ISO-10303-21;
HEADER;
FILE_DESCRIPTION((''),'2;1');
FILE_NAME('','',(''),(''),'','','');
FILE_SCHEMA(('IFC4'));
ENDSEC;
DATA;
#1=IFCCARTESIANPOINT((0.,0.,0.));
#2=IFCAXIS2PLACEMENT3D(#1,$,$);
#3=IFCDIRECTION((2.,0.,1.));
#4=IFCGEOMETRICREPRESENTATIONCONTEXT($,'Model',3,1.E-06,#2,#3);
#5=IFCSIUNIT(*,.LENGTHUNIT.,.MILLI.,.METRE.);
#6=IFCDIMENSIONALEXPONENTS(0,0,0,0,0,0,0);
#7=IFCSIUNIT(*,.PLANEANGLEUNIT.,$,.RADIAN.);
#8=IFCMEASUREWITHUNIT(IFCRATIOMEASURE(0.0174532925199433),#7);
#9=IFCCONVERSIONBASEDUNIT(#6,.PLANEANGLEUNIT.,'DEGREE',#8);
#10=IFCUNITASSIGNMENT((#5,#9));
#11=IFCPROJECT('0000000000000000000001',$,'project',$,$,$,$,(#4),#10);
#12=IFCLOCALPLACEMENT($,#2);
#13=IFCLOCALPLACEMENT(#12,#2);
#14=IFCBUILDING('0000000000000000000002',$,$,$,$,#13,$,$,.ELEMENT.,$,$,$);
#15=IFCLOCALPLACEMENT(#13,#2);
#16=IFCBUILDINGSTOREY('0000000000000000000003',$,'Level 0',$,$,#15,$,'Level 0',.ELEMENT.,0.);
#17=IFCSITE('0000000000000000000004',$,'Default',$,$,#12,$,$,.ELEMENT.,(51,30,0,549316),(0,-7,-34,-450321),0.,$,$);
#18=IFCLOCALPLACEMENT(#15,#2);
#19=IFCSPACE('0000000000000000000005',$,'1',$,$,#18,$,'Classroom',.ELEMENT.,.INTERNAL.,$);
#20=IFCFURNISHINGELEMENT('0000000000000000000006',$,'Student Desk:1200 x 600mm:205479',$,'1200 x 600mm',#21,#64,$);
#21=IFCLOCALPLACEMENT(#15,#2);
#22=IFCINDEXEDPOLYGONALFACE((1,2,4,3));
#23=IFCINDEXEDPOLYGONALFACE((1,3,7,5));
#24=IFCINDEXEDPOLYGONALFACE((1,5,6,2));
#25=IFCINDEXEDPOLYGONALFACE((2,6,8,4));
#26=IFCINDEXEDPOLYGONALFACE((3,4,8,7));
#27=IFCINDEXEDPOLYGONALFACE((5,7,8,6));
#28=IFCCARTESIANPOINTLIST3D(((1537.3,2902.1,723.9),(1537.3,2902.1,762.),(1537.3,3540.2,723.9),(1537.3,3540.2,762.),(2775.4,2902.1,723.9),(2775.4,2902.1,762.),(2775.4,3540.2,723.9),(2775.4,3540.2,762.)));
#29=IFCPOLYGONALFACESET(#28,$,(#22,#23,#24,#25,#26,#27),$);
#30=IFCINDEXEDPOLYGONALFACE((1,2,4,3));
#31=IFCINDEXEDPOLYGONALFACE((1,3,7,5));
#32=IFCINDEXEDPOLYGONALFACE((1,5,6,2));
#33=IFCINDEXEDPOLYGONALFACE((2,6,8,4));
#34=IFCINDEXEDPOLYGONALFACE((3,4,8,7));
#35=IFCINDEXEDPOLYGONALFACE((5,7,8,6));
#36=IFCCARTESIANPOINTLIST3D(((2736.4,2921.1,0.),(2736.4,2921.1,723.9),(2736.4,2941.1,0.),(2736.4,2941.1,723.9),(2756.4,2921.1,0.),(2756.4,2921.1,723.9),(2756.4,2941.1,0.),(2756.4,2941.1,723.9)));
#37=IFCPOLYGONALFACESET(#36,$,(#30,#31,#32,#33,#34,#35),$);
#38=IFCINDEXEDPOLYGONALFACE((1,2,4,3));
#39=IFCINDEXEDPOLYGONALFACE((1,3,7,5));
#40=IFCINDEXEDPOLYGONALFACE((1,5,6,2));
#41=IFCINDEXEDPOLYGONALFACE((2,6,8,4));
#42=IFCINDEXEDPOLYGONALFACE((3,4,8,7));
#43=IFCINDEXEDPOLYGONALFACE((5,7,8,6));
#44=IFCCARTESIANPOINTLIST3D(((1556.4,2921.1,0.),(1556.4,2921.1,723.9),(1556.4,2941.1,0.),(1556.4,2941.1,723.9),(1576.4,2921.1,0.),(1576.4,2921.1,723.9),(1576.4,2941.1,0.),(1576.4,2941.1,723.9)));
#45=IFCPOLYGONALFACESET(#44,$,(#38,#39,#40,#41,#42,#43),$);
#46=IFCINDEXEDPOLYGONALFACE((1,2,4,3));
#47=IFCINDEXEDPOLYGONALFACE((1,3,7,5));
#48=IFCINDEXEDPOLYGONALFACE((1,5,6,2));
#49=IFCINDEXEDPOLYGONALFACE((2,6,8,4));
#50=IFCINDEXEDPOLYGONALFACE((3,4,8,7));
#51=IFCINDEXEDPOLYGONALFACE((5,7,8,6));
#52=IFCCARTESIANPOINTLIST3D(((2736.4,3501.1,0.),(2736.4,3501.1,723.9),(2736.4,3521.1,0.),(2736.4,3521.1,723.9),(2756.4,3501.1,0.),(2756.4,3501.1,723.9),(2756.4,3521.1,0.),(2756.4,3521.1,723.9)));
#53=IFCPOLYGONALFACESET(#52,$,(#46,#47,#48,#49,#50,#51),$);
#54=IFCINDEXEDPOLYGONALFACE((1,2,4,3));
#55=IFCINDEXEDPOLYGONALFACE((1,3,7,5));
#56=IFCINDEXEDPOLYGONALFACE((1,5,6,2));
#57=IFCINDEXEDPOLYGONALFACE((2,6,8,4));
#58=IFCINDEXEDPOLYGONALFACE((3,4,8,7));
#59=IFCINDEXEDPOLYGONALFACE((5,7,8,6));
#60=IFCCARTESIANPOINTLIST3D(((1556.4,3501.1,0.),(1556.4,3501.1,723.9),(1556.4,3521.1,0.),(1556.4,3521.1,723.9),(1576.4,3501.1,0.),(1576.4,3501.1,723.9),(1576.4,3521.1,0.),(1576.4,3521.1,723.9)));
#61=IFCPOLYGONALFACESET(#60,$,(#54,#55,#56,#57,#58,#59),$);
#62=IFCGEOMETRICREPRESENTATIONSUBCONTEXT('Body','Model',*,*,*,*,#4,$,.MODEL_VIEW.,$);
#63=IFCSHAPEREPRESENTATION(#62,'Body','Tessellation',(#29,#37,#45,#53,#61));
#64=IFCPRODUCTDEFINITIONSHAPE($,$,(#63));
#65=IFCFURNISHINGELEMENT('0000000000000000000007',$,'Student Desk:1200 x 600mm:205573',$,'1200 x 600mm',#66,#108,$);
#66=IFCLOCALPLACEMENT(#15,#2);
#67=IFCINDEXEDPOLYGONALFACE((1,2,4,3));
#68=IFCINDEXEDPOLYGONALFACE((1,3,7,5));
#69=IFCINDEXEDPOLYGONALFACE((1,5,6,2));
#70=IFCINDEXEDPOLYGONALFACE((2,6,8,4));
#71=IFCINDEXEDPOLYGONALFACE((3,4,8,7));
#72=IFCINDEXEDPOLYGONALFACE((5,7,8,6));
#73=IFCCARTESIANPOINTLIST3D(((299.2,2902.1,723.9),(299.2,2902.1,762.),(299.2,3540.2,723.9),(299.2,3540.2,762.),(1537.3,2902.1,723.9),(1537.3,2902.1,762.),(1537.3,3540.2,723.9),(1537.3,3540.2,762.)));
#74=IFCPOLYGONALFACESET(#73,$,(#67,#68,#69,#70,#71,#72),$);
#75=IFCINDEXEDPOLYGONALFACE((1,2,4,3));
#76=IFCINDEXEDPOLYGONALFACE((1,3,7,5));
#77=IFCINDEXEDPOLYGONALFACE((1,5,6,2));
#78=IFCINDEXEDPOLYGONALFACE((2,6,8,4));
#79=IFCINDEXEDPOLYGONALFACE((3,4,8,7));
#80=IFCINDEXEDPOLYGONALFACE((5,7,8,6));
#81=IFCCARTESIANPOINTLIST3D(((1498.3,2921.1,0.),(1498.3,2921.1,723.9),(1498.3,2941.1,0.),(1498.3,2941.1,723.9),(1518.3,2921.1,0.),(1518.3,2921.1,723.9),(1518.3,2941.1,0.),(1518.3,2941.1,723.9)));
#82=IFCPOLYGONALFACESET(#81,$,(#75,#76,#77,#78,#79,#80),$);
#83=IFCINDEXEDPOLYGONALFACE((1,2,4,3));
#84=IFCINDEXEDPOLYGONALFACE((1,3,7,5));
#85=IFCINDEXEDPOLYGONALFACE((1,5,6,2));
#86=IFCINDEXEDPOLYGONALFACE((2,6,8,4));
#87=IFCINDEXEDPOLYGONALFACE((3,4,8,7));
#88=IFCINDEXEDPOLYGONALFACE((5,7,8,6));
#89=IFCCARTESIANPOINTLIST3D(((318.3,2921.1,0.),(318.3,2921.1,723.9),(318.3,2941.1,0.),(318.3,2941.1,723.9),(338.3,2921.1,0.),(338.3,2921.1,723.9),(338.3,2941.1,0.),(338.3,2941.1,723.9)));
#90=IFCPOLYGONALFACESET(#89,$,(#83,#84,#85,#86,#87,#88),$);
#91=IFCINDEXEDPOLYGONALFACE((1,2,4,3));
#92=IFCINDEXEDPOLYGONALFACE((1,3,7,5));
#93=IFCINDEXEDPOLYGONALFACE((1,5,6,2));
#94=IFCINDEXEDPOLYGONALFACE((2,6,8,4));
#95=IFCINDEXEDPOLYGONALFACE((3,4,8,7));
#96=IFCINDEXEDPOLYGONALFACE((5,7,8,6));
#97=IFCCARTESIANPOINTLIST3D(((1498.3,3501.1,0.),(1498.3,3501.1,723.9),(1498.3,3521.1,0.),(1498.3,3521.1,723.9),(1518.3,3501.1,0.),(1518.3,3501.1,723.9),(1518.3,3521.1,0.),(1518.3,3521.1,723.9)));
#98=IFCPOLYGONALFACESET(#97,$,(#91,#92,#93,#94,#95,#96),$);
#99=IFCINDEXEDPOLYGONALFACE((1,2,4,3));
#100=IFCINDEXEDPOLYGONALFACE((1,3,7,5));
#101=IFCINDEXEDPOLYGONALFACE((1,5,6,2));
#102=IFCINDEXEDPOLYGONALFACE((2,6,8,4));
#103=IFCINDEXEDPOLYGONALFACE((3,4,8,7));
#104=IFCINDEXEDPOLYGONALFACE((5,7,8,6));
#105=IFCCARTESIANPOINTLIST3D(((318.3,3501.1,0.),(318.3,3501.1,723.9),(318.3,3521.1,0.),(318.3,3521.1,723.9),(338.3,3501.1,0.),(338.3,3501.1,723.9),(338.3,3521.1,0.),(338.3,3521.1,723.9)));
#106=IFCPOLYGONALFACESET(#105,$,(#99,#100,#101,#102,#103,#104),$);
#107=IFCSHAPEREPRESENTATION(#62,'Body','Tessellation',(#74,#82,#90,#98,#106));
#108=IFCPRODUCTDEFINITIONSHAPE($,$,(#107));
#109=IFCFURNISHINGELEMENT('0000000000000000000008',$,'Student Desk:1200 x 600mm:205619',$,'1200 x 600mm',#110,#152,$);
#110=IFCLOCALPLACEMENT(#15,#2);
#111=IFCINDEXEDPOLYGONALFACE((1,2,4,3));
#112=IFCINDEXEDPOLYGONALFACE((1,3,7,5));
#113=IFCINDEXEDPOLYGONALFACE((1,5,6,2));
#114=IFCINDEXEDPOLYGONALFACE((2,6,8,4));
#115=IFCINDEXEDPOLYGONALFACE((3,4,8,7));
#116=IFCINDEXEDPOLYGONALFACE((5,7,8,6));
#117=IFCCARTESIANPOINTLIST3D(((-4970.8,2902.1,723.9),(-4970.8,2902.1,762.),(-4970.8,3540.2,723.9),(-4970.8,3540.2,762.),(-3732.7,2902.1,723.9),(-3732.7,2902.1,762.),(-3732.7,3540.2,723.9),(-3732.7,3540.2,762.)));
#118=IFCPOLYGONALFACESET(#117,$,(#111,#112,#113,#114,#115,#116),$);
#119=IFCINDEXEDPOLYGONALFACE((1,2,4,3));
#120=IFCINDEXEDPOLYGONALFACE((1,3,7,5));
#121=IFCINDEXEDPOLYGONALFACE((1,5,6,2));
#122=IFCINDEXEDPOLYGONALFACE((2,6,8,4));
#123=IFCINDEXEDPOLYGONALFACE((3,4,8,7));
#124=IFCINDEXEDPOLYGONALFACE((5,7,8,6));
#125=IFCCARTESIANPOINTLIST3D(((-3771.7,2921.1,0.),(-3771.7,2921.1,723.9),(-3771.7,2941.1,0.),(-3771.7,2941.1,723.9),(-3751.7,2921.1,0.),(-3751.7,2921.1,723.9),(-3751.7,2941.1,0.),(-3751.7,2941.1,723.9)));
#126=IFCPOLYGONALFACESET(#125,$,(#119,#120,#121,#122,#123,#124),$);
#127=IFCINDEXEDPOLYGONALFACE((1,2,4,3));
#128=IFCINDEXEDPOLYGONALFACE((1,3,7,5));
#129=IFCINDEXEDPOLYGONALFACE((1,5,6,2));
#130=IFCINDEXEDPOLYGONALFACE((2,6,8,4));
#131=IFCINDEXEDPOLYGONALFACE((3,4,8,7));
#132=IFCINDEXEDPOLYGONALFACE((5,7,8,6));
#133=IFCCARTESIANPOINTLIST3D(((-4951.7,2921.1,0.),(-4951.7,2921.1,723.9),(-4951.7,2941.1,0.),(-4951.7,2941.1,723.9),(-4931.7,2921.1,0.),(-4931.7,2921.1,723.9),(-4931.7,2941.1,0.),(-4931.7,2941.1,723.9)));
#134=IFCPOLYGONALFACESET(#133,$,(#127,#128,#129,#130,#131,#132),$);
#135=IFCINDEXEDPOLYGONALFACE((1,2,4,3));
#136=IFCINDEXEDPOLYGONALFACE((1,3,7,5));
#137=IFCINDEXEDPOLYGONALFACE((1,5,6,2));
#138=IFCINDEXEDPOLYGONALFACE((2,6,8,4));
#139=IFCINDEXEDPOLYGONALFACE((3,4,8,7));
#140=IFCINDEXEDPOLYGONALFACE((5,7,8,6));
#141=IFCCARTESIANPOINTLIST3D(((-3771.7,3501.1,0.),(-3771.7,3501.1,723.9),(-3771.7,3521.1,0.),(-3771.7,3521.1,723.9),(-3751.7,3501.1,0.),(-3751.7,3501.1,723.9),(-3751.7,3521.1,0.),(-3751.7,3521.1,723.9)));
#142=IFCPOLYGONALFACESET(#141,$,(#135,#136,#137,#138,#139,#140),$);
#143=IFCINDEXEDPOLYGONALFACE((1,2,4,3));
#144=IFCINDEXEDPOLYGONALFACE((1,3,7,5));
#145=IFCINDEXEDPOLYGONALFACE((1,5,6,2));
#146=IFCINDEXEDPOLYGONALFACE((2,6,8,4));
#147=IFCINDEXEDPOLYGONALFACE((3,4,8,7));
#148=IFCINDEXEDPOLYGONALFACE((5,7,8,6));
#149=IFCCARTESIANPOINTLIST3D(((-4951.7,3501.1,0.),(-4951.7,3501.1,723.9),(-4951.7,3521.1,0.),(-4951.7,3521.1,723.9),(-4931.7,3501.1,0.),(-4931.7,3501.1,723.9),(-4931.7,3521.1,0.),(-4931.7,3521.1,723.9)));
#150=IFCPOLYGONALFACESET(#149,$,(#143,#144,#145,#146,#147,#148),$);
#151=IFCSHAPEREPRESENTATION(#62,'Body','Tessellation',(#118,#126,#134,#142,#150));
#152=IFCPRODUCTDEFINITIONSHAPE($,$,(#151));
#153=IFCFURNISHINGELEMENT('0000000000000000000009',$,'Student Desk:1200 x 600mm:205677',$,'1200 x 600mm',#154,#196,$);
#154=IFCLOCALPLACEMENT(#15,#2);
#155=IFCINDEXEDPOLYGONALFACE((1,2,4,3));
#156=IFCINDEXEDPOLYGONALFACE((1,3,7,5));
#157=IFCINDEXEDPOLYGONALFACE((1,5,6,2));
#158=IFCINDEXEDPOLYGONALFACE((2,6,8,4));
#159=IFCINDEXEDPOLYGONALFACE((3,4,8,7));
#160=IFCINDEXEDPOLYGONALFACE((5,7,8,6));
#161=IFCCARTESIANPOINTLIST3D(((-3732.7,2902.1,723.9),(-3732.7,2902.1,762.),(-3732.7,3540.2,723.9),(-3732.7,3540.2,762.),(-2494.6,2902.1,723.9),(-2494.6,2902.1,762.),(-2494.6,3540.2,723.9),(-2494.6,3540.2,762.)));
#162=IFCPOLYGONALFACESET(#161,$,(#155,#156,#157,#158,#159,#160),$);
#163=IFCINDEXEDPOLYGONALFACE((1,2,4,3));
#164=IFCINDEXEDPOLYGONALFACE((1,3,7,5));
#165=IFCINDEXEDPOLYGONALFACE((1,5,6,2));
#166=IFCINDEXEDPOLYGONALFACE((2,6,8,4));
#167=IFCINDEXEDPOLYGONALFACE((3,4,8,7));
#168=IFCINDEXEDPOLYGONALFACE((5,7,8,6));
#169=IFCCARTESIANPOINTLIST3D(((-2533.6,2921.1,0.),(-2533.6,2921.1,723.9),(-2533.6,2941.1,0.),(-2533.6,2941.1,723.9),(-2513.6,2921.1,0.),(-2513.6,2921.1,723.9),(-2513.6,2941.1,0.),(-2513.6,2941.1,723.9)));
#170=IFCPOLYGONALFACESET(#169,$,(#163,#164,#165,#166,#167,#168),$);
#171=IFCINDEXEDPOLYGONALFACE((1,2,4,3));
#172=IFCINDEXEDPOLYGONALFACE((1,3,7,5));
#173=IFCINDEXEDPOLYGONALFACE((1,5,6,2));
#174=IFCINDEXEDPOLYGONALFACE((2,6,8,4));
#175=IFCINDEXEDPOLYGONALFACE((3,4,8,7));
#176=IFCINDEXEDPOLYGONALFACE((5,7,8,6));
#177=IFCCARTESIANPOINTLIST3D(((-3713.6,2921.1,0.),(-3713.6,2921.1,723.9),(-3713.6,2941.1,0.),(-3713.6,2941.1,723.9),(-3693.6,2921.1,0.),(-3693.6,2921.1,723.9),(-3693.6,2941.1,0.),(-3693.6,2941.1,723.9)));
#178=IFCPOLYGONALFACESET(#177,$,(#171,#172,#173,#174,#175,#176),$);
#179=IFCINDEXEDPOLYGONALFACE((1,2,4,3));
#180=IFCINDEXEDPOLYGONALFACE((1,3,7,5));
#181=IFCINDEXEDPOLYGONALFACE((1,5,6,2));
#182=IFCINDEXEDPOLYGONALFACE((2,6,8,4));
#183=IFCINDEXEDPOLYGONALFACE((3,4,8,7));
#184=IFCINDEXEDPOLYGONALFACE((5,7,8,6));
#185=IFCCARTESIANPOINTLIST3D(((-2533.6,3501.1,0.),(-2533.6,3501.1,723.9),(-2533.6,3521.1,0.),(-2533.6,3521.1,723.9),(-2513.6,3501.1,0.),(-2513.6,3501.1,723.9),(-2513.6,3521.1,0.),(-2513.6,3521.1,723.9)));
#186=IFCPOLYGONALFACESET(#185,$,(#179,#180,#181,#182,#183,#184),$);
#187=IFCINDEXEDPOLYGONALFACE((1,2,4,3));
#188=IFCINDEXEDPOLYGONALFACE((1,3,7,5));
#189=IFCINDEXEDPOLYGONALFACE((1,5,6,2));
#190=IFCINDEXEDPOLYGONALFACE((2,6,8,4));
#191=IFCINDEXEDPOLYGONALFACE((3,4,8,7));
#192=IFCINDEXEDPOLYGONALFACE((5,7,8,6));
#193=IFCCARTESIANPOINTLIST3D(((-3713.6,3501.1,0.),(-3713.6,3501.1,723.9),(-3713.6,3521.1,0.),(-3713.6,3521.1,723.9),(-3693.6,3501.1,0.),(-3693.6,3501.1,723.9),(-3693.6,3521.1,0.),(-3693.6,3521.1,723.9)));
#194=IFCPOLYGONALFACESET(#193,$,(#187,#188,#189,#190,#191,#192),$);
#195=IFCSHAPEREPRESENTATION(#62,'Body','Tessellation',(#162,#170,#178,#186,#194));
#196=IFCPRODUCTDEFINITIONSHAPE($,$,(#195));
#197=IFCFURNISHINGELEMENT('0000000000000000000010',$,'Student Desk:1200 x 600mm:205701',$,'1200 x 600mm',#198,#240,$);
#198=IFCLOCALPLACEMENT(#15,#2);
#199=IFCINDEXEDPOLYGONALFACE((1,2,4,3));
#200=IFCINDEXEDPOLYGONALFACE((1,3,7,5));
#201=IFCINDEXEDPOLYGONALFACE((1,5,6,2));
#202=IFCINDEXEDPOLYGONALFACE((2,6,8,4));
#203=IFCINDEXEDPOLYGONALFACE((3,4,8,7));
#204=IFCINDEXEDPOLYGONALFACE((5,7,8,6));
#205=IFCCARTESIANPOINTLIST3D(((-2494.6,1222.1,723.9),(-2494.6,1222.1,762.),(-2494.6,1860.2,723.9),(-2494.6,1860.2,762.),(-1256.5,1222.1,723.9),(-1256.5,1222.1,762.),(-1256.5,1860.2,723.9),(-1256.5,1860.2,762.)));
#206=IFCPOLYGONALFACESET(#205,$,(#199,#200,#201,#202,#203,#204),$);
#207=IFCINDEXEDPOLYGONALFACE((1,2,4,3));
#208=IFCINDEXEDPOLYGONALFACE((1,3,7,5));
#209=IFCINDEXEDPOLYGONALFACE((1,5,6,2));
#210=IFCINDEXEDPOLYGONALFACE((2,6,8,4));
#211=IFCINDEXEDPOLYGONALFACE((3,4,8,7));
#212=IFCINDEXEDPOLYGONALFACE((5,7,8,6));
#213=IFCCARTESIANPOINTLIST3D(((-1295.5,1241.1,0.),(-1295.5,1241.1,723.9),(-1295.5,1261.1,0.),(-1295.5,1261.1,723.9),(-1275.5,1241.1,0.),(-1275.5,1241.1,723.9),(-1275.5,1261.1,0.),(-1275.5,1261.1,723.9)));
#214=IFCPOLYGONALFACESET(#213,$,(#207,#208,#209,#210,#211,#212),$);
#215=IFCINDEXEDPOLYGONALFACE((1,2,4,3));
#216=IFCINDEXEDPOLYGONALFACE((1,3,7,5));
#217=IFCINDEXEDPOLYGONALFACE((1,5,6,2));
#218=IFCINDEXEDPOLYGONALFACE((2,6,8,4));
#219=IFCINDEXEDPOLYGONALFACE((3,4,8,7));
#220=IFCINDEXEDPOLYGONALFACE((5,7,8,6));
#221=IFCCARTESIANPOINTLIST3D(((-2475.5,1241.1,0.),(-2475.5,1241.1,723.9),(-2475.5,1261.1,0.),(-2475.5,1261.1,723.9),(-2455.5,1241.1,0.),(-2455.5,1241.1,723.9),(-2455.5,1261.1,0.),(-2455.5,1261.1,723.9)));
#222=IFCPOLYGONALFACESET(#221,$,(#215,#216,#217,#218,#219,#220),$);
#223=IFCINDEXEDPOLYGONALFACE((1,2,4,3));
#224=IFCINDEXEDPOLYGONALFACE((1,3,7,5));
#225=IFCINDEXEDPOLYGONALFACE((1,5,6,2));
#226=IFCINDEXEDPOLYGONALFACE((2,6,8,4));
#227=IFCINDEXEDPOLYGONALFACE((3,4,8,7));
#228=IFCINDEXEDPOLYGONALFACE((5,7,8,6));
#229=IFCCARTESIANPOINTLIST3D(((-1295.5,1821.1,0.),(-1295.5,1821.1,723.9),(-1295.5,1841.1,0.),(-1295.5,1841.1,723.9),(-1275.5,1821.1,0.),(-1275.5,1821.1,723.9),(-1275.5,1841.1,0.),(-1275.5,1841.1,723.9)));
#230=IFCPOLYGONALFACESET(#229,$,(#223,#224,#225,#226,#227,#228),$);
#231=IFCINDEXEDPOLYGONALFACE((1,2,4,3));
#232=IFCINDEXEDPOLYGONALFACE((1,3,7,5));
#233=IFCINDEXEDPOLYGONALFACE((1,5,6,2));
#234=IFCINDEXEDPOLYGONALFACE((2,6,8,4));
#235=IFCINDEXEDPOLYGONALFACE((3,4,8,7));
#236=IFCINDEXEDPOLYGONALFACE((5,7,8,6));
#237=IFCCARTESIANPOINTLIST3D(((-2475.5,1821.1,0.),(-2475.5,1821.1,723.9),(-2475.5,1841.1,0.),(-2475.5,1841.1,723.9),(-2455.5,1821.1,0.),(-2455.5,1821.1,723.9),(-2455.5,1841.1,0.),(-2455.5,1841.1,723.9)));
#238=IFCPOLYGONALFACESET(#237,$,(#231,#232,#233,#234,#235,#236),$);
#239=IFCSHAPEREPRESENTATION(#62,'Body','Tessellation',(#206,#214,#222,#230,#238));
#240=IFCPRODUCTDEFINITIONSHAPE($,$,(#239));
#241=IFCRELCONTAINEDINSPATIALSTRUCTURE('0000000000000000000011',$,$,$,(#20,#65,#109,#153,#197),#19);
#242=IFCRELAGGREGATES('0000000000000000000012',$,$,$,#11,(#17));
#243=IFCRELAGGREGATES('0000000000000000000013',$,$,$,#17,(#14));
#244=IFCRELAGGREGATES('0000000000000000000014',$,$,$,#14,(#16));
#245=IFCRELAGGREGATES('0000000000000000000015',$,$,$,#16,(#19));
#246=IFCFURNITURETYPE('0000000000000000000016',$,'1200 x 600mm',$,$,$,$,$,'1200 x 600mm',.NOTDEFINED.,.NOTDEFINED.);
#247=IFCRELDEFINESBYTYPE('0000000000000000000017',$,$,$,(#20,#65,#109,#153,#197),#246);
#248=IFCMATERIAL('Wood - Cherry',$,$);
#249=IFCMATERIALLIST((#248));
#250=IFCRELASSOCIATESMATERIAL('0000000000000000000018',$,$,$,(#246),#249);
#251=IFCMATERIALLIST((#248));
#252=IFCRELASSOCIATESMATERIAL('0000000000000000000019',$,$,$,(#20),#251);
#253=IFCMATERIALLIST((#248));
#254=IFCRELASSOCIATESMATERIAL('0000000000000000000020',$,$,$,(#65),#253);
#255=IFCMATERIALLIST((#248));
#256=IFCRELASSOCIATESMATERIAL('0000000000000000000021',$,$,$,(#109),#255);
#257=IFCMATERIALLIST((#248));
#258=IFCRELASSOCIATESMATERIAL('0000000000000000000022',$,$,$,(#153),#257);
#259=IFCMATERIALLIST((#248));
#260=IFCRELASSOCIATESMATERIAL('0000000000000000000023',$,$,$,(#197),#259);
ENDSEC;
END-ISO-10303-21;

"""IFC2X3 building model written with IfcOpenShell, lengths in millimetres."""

from ifc_helpers import new_model, entity, si_unit, converted_unit, direction, frame, frame_2d, origin, origin_2d_with_axis, place, context, subcontext, project, spatial, rectangle, extrude, source, transform, mapped, material, material_list, type_object, type_shapes, element, save


model = new_model("IFC2X3")

# Units and contexts
model_context = context("Model", 3, precision=1e-06, world=origin(), true_north=direction((2.0, 0.0, 1.0)))
body_context = subcontext(model_context, "Body", "Model", "MODEL_VIEW")
ifc_project = project(units=[si_unit("LENGTHUNIT", "METRE", prefix="MILLI"), converted_unit("PLANEANGLEUNIT", "DEGREE", entity("IfcRatioMeasure", 0.0174532925199433), si_unit("PLANEANGLEUNIT", "RADIAN"), dimensions=[0, 0, 0, 0, 0, 0, 0])], contexts=[model_context])

# Site, building, storey
site_placement = place(None, origin())
site = spatial("IfcSite", under=ifc_project, at=site_placement, Name="Default", CompositionType="ELEMENT", RefLatitude=(51, 30, 0, 549316), RefLongitude=(0, -7, -34, -450321), RefElevation=0.0)
building_placement = place(site_placement, origin())
building = spatial("IfcBuilding", under=site, at=building_placement, CompositionType="ELEMENT")
storey_placement = place(building_placement, origin())
storey = spatial("IfcBuildingStorey", under=building, at=storey_placement, Name="Level 0", LongName="Level 0", CompositionType="ELEMENT", Elevation=0.0)

# Shared definitions
space_placement = place(storey_placement, origin())
space = spatial("IfcSpace", under=storey, at=space_placement, Name="1", LongName="Classroom", CompositionType="ELEMENT", InteriorOrExteriorSpace="INTERNAL")

# Furnishing elements
ifc_material_1 = material(Name="Wood - Cherry")
ifc_material_list_1 = material_list([ifc_material_1])
ifc_material_list_2 = material_list([ifc_material_1])
furniture_type = type_object("IfcFurnitureType", Name="1200 x 600mm", ElementType="1200 x 600mm", AssemblyPlace="NOTDEFINED", material=ifc_material_list_2)
shared_shape_1 = source(origin(), body_context, "Body", "SweptSolid", [
    extrude(rectangle(XDim=1238.1, YDim=638.1, at=origin_2d_with_axis()), frame((600.0, 300.0, 723.9), z_axis=(0.0, 0.0, 1.0), x_axis=(-1.0, 0.0, 0.0)), (0.0, 0.0, 1.0), 38.1),
    extrude(rectangle(XDim=20.0, YDim=20.0, at=origin_2d_with_axis()), frame((1190.0, 10.0, 0.0)), (0.0, 0.0, 1.0), 723.9),
    extrude(rectangle(XDim=20.0, YDim=20.0, at=frame_2d((0.0, 0.0), x_axis=(1.0, 0.0))), frame((10.0, 10.0, 0.0), z_axis=(0.0, 0.0, 1.0), x_axis=(0.0, 1.0, 0.0)), (0.0, 0.0, 1.0), 723.9),
    extrude(rectangle(XDim=20.0, YDim=20.0, at=frame_2d((0.0, 0.0), x_axis=(1.0, 0.0))), frame((1190.0, 590.0, 0.0), z_axis=(0.0, 0.0, 1.0), x_axis=(0.0, -1.0, 0.0)), (0.0, 0.0, 1.0), 723.9),
    extrude(rectangle(XDim=20.0, YDim=20.0, at=origin_2d_with_axis()), frame((10.0, 590.0, 0.0), z_axis=(0.0, 0.0, 1.0), x_axis=(-1.0, 0.0, 0.0)), (0.0, 0.0, 1.0), 723.9),
])
type_shapes(furniture_type, [shared_shape_1])
furnishing_1_placement = place(space_placement, frame((1556.4, 2921.1, 0.0)))
element("IfcFurnishingElement", 1, at=furnishing_1_placement, inside=space, type_object=furniture_type, material=ifc_material_list_1, Name="Student Desk:1200 x 600mm:205479", ObjectType="1200 x 600mm", context=body_context, shape_type="MappedRepresentation", body=[
    mapped(shared_shape_1, transform((0.0, 0.0, 0.0), scale=1.0)),
])
ifc_material_list_3 = material_list([ifc_material_1])
furnishing_2_placement = place(space_placement, frame((318.3, 2921.1, 0.0)))
element("IfcFurnishingElement", 2, at=furnishing_2_placement, inside=space, type_object=furniture_type, material=ifc_material_list_3, Name="Student Desk:1200 x 600mm:205573", ObjectType="1200 x 600mm", context=body_context, shape_type="MappedRepresentation", body=[
    mapped(shared_shape_1, transform((0.0, 0.0, 0.0), scale=1.0)),
])
ifc_material_list_4 = material_list([ifc_material_1])
furnishing_3_placement = place(space_placement, frame((-4951.7, 2921.1, 0.0)))
element("IfcFurnishingElement", 3, at=furnishing_3_placement, inside=space, type_object=furniture_type, material=ifc_material_list_4, Name="Student Desk:1200 x 600mm:205619", ObjectType="1200 x 600mm", context=body_context, shape_type="MappedRepresentation", body=[
    mapped(shared_shape_1, transform((0.0, 0.0, 0.0), scale=1.0)),
])
ifc_material_list_5 = material_list([ifc_material_1])
furnishing_4_placement = place(space_placement, frame((-3713.6, 2921.1, 0.0)))
element("IfcFurnishingElement", 4, at=furnishing_4_placement, inside=space, type_object=furniture_type, material=ifc_material_list_5, Name="Student Desk:1200 x 600mm:205677", ObjectType="1200 x 600mm", context=body_context, shape_type="MappedRepresentation", body=[
    mapped(shared_shape_1, transform((0.0, 0.0, 0.0), scale=1.0)),
])
ifc_material_list_6 = material_list([ifc_material_1])
furnishing_5_placement = place(space_placement, frame((-2475.5, 1241.1, 0.0)))
element("IfcFurnishingElement", 5, at=furnishing_5_placement, inside=space, type_object=furniture_type, material=ifc_material_list_6, Name="Student Desk:1200 x 600mm:205701", ObjectType="1200 x 600mm", context=body_context, shape_type="MappedRepresentation", body=[
    mapped(shared_shape_1, transform((0.0, 0.0, 0.0), scale=1.0)),
])

save(model, "model.ifc")
